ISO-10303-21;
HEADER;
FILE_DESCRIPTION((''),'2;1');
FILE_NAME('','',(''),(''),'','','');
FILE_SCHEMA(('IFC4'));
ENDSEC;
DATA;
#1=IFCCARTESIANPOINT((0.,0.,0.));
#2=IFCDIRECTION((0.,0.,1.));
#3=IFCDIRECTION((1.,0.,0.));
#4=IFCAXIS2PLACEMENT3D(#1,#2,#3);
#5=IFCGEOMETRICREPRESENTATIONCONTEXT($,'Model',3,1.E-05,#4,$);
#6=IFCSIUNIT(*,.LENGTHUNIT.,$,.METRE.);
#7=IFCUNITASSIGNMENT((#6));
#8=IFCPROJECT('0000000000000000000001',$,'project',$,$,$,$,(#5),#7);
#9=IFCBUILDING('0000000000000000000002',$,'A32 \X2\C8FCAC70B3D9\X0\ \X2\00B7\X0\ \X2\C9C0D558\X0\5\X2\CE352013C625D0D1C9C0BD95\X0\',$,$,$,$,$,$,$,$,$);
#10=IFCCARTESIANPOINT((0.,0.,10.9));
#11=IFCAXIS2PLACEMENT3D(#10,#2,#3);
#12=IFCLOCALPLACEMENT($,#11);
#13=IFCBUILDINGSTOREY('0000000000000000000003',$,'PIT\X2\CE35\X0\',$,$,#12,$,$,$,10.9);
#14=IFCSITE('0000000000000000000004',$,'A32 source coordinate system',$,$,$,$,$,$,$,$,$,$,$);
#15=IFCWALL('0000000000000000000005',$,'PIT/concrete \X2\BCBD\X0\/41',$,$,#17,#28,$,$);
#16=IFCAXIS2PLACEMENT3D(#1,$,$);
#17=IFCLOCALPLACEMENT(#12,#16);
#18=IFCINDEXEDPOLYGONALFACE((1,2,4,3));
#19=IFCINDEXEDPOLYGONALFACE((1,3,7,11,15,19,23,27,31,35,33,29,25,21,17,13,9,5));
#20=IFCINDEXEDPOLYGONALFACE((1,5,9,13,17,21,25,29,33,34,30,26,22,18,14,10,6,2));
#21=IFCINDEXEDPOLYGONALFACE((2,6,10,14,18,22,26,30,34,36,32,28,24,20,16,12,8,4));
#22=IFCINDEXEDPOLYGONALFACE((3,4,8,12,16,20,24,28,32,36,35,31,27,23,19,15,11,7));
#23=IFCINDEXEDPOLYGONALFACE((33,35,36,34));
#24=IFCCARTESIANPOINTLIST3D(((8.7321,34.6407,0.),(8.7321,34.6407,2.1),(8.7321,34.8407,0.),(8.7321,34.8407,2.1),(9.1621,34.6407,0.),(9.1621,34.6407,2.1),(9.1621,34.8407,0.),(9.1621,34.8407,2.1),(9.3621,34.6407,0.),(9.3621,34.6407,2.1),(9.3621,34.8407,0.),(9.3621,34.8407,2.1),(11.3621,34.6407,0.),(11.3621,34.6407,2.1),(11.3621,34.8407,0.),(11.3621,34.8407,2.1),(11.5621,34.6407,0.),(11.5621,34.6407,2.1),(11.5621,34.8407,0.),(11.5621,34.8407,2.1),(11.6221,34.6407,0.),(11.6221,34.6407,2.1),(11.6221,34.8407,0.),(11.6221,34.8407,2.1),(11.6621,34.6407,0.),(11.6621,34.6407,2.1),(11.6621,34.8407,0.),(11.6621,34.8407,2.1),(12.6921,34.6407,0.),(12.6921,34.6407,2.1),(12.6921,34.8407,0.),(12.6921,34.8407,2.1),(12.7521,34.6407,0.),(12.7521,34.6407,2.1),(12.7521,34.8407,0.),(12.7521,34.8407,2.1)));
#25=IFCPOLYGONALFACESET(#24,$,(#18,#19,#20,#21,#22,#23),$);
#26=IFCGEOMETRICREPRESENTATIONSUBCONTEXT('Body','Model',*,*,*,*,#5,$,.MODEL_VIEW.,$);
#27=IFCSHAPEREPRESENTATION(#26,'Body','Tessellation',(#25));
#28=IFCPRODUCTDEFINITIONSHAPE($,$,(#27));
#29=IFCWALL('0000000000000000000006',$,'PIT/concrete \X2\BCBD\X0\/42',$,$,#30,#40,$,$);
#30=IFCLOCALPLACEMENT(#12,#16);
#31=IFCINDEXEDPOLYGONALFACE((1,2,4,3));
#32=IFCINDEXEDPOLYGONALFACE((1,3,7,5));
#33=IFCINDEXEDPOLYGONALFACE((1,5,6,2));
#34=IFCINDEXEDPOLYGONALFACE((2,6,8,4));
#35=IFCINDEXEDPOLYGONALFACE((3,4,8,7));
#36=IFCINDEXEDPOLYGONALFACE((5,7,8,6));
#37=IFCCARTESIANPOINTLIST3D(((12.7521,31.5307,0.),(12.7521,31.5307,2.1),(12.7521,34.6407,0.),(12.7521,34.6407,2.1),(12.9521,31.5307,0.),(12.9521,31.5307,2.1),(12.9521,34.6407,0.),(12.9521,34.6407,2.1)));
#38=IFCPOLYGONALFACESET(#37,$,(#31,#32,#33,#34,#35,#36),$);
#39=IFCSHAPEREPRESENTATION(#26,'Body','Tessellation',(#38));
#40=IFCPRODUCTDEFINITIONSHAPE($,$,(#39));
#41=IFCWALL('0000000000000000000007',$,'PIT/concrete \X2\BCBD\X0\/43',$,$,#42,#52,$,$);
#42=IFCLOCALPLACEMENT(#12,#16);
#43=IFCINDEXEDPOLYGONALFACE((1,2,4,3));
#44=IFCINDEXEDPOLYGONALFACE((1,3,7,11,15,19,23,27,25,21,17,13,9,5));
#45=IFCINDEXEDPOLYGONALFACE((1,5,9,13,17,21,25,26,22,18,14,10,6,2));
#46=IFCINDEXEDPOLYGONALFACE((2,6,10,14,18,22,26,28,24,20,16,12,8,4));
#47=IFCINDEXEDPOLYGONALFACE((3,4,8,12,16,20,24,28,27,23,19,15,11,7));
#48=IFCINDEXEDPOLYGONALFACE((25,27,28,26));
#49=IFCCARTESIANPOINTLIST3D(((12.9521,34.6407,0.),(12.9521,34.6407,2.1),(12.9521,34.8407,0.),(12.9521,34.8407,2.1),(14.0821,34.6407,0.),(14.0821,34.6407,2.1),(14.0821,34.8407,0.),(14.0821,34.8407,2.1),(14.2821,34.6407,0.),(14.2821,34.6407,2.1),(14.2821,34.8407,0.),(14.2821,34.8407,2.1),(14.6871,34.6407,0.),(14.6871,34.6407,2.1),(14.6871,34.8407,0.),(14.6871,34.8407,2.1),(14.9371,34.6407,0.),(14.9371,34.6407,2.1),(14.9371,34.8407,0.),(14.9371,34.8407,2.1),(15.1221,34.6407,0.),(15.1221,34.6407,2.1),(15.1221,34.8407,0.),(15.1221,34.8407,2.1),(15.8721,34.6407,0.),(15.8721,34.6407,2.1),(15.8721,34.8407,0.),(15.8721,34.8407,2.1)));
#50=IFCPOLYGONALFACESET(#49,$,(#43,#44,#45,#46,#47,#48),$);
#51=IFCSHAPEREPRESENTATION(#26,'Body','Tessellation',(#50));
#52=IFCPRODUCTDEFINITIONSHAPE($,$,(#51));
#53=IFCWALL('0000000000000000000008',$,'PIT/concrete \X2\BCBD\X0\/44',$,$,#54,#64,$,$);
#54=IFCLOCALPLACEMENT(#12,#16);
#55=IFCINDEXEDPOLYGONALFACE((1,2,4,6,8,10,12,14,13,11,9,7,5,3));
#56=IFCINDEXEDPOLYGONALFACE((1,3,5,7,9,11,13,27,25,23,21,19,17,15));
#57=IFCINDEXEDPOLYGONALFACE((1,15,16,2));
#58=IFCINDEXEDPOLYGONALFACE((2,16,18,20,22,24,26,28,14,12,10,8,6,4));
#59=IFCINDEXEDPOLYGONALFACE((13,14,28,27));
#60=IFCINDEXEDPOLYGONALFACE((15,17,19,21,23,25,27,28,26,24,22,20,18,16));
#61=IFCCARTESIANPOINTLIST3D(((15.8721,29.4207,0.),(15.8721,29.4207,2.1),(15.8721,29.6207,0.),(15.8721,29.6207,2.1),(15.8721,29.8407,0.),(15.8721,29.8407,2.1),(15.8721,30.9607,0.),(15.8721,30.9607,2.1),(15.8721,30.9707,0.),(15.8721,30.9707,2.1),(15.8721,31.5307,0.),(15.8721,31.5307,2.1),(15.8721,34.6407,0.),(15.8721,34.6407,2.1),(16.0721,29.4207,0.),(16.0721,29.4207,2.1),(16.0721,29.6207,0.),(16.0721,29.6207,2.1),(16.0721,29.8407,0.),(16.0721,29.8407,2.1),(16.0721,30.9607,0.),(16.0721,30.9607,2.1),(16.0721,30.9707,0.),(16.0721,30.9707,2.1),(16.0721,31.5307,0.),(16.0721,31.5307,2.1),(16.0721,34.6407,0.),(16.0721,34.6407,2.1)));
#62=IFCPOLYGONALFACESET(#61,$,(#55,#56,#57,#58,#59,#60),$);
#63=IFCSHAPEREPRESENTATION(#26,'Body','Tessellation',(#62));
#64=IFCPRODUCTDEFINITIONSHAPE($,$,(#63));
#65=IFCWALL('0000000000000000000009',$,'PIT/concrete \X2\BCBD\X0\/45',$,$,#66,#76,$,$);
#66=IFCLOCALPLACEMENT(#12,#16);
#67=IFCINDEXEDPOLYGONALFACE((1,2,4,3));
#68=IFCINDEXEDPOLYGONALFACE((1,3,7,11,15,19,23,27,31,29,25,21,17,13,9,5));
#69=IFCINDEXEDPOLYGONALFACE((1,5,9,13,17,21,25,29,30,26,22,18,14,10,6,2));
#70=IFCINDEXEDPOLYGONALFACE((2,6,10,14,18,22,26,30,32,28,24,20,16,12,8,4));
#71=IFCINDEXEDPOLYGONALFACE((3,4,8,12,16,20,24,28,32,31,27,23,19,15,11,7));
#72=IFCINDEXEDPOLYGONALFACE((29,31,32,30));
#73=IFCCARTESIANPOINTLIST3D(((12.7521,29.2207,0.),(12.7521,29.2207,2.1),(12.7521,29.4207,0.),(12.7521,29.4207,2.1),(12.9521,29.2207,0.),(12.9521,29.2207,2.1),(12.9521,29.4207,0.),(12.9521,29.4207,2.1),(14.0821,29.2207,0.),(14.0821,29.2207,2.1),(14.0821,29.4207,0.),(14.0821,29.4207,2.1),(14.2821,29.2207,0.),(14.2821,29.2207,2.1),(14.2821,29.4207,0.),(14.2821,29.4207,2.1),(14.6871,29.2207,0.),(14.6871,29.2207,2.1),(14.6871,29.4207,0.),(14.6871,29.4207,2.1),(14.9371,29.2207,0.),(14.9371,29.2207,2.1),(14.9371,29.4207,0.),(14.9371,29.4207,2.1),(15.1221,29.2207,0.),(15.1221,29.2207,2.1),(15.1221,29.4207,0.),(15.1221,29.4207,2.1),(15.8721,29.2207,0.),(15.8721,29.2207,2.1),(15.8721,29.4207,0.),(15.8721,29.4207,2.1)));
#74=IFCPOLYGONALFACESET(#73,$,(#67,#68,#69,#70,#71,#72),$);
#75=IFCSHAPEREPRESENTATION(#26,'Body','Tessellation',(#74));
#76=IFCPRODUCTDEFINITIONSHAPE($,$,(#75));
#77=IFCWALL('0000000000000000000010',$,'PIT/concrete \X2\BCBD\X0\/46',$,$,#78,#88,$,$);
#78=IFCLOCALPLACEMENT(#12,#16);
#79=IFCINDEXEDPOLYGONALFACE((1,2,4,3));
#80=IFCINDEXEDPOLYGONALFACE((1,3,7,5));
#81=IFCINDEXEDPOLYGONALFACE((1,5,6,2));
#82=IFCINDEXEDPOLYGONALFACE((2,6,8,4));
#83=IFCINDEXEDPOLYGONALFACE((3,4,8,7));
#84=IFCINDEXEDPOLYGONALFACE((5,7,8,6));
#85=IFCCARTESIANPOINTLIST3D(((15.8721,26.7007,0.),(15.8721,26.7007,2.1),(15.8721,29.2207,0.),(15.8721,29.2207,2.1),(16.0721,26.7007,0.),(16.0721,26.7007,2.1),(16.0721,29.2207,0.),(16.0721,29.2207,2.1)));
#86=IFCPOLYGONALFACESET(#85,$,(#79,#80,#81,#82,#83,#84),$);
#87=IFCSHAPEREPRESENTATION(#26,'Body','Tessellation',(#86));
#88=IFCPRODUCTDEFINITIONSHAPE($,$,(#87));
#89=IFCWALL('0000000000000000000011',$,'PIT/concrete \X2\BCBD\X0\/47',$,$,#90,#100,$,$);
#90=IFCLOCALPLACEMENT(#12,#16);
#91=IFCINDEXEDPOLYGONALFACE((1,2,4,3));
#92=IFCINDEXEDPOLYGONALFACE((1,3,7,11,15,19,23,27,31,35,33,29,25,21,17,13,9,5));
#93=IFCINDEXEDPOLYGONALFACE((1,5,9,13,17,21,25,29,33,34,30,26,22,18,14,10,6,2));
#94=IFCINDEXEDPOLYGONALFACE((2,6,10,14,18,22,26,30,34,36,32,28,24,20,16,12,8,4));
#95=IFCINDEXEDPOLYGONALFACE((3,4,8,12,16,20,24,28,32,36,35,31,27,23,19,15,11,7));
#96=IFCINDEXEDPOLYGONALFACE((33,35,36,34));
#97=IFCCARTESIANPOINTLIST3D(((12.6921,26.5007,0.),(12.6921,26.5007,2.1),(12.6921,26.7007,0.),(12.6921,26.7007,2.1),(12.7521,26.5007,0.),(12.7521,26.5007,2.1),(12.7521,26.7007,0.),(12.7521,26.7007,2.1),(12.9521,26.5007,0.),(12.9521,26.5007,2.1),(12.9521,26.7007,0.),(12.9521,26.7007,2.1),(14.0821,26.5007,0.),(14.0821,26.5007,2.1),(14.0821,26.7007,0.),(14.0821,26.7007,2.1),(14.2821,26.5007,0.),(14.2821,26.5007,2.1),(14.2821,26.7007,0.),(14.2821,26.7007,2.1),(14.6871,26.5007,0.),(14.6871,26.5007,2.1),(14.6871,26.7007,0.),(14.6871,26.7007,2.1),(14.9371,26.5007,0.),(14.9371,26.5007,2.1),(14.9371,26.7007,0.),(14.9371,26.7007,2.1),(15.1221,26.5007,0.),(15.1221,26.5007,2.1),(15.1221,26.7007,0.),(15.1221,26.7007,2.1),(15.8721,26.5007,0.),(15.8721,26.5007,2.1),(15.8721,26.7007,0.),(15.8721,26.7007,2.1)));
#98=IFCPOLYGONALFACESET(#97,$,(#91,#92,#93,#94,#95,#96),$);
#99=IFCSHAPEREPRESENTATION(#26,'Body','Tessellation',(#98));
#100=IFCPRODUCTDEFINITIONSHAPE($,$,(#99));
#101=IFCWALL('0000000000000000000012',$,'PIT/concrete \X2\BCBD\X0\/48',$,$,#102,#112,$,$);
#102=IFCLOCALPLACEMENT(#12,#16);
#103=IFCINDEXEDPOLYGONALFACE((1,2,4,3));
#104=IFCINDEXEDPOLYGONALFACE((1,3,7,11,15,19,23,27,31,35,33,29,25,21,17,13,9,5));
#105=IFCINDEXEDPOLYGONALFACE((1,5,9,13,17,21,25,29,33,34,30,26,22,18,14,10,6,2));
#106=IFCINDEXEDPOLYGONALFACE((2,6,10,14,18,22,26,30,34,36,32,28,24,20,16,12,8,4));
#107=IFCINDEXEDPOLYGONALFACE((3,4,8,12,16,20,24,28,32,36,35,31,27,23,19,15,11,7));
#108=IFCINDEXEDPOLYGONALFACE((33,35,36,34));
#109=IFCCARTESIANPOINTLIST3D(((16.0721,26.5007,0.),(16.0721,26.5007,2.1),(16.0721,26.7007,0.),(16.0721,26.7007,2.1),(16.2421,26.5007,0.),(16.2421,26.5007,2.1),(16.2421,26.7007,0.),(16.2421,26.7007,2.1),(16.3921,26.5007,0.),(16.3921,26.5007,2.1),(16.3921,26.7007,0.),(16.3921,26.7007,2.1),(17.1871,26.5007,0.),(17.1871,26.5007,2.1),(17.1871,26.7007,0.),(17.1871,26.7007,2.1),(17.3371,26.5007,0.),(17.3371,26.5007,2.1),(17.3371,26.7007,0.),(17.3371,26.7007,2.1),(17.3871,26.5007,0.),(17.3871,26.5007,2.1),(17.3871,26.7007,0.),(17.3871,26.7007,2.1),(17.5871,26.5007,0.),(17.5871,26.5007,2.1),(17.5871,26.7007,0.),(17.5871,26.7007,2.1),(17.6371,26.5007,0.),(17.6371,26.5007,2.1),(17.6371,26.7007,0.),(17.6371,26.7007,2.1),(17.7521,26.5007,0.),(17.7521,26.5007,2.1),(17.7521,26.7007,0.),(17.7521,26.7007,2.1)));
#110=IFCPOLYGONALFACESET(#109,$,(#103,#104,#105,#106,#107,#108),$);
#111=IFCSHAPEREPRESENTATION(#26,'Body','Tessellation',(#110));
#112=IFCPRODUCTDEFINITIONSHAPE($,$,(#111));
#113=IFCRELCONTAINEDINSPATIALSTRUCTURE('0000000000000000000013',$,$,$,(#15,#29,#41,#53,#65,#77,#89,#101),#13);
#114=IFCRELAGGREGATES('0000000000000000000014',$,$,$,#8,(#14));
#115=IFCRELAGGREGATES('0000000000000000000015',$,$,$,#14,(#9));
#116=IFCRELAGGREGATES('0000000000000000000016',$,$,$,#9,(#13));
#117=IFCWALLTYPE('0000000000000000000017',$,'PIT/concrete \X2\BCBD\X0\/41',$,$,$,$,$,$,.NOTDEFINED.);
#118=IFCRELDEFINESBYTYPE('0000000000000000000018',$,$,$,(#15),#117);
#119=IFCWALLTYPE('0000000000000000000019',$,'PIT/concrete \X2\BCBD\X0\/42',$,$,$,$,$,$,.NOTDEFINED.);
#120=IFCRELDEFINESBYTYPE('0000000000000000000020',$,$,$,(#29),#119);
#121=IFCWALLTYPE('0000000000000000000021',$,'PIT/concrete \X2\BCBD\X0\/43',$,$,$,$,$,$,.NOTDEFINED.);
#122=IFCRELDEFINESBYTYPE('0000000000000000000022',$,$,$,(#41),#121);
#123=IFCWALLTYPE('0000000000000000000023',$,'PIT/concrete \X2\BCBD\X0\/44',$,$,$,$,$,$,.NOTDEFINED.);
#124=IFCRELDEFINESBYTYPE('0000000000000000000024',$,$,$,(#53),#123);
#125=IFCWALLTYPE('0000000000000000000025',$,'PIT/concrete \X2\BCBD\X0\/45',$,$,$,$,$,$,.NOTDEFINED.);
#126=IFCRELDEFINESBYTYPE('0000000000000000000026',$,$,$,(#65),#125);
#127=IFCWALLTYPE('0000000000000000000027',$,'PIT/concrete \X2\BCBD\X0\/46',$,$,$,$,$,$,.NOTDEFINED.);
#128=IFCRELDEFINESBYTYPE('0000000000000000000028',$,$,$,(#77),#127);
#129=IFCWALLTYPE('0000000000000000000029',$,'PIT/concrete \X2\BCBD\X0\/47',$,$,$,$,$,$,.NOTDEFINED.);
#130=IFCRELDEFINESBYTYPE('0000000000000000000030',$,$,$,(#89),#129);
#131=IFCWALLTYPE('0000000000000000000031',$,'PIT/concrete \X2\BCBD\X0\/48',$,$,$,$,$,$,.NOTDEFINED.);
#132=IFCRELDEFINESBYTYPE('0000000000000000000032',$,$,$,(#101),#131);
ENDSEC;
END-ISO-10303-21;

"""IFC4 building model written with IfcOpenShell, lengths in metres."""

from ifc_helpers import new_model, si_unit, frame, origin, origin_with_axes, place, context, subcontext, project, spatial, polyline, outline, extrude, source, transform, mapped, type_object, type_shapes, element, save


model = new_model("IFC4")

# Units and contexts
model_context = context("Model", 3, precision=1e-05, world=origin_with_axes())
body_context = subcontext(model_context, "Body", "Model", "MODEL_VIEW")
ifc_project = project(units=[si_unit("LENGTHUNIT", "METRE")], contexts=[model_context])

# Site, building, storey
site = spatial("IfcSite", under=ifc_project, Name="A32 source coordinate system")
building = spatial("IfcBuilding", under=site, Name="A32 주거동 · 지하5층–옥탑지붕")
storey_placement = place(None, frame((0.0, 0.0, 10.9), z_axis=(0.0, 0.0, 1.0), x_axis=(1.0, 0.0, 0.0)))
storey = spatial("IfcBuildingStorey", under=building, at=storey_placement, Name="PIT층", Elevation=10.9)

# Walls
wall_type_1 = type_object("IfcWallType", Name="PIT/concrete 벽/41", PredefinedType="NOTDEFINED")
shared_shape_1 = source(origin(), body_context, "Body", "SweptSolid", [
    extrude(outline(polyline([(9.3621, 34.8407), (11.3621, 34.8407), (11.5621, 34.8407), (11.6221, 34.8407), (11.6621, 34.8407), (12.6921, 34.8407), (12.7521, 34.8407), (12.7521, 34.6407), (12.6921, 34.6407), (11.6621, 34.6407), (11.6221, 34.6407), (11.5621, 34.6407), (11.3621, 34.6407), (9.3621, 34.6407), (9.1621, 34.6407), (8.7321, 34.6407), (8.7321, 34.8407), (9.1621, 34.8407), (9.3621, 34.8407)])), origin(), (0.0, 0.0, 1.0), 2.1),
])
type_shapes(wall_type_1, [shared_shape_1])
wall_1_placement = place(storey_placement, origin_with_axes())
element("IfcWall", 1, at=wall_1_placement, inside=storey, type_object=wall_type_1, Name="PIT/concrete 벽/41", context=body_context, shape_type="MappedRepresentation", body=[
    mapped(shared_shape_1, transform((0.0, 0.0, 0.0), scale=1.0)),
])
wall_type_2 = type_object("IfcWallType", Name="PIT/concrete 벽/42", PredefinedType="NOTDEFINED")
shared_shape_2 = source(origin(), body_context, "Body", "SweptSolid", [
    extrude(outline(polyline([(12.7521, 31.5307), (12.7521, 34.6407), (12.9521, 34.6407), (12.9521, 31.5307), (12.7521, 31.5307)])), origin(), (0.0, 0.0, 1.0), 2.1),
])
type_shapes(wall_type_2, [shared_shape_2])
wall_2_placement = place(storey_placement, origin_with_axes())
element("IfcWall", 2, at=wall_2_placement, inside=storey, type_object=wall_type_2, Name="PIT/concrete 벽/42", context=body_context, shape_type="MappedRepresentation", body=[
    mapped(shared_shape_2, transform((0.0, 0.0, 0.0), scale=1.0)),
])
wall_type_3 = type_object("IfcWallType", Name="PIT/concrete 벽/43", PredefinedType="NOTDEFINED")
shared_shape_3 = source(origin(), body_context, "Body", "SweptSolid", [
    extrude(outline(polyline([(14.2821, 34.8407), (14.6871, 34.8407), (14.9371, 34.8407), (15.1221, 34.8407), (15.8721, 34.8407), (15.8721, 34.6407), (15.1221, 34.6407), (14.9371, 34.6407), (14.6871, 34.6407), (14.2821, 34.6407), (14.0821, 34.6407), (12.9521, 34.6407), (12.9521, 34.8407), (14.0821, 34.8407), (14.2821, 34.8407)])), origin(), (0.0, 0.0, 1.0), 2.1),
])
type_shapes(wall_type_3, [shared_shape_3])
wall_3_placement = place(storey_placement, origin_with_axes())
element("IfcWall", 3, at=wall_3_placement, inside=storey, type_object=wall_type_3, Name="PIT/concrete 벽/43", context=body_context, shape_type="MappedRepresentation", body=[
    mapped(shared_shape_3, transform((0.0, 0.0, 0.0), scale=1.0)),
])
wall_type_4 = type_object("IfcWallType", Name="PIT/concrete 벽/44", PredefinedType="NOTDEFINED")
shared_shape_4 = source(origin(), body_context, "Body", "SweptSolid", [
    extrude(outline(polyline([(16.0721, 30.9707), (16.0721, 30.9607), (16.0721, 29.8407), (16.0721, 29.6207), (16.0721, 29.4207), (15.8721, 29.4207), (15.8721, 29.6207), (15.8721, 29.8407), (15.8721, 30.9607), (15.8721, 30.9707), (15.8721, 31.5307), (15.8721, 34.6407), (16.0721, 34.6407), (16.0721, 31.5307), (16.0721, 30.9707)])), origin(), (0.0, 0.0, 1.0), 2.1),
])
type_shapes(wall_type_4, [shared_shape_4])
wall_4_placement = place(storey_placement, origin_with_axes())
element("IfcWall", 4, at=wall_4_placement, inside=storey, type_object=wall_type_4, Name="PIT/concrete 벽/44", context=body_context, shape_type="MappedRepresentation", body=[
    mapped(shared_shape_4, transform((0.0, 0.0, 0.0), scale=1.0)),
])
wall_type_5 = type_object("IfcWallType", Name="PIT/concrete 벽/45", PredefinedType="NOTDEFINED")
shared_shape_5 = source(origin(), body_context, "Body", "SweptSolid", [
    extrude(outline(polyline([(14.9371, 29.2207), (14.6871, 29.2207), (14.2821, 29.2207), (14.0821, 29.2207), (12.9521, 29.2207), (12.7521, 29.2207), (12.7521, 29.4207), (12.9521, 29.4207), (14.0821, 29.4207), (14.2821, 29.4207), (14.6871, 29.4207), (14.9371, 29.4207), (15.1221, 29.4207), (15.8721, 29.4207), (15.8721, 29.2207), (15.1221, 29.2207), (14.9371, 29.2207)])), origin(), (0.0, 0.0, 1.0), 2.1),
])
type_shapes(wall_type_5, [shared_shape_5])
wall_5_placement = place(storey_placement, origin_with_axes())
element("IfcWall", 5, at=wall_5_placement, inside=storey, type_object=wall_type_5, Name="PIT/concrete 벽/45", context=body_context, shape_type="MappedRepresentation", body=[
    mapped(shared_shape_5, transform((0.0, 0.0, 0.0), scale=1.0)),
])
wall_type_6 = type_object("IfcWallType", Name="PIT/concrete 벽/46", PredefinedType="NOTDEFINED")
shared_shape_6 = source(origin(), body_context, "Body", "SweptSolid", [
    extrude(outline(polyline([(15.8721, 26.7007), (15.8721, 29.2207), (16.0721, 29.2207), (16.0721, 26.7007), (15.8721, 26.7007)])), origin(), (0.0, 0.0, 1.0), 2.1),
])
type_shapes(wall_type_6, [shared_shape_6])
wall_6_placement = place(storey_placement, origin_with_axes())
element("IfcWall", 6, at=wall_6_placement, inside=storey, type_object=wall_type_6, Name="PIT/concrete 벽/46", context=body_context, shape_type="MappedRepresentation", body=[
    mapped(shared_shape_6, transform((0.0, 0.0, 0.0), scale=1.0)),
])
wall_type_7 = type_object("IfcWallType", Name="PIT/concrete 벽/47", PredefinedType="NOTDEFINED")
shared_shape_7 = source(origin(), body_context, "Body", "SweptSolid", [
    extrude(outline(polyline([(14.9371, 26.5007), (14.6871, 26.5007), (14.2821, 26.5007), (14.0821, 26.5007), (12.9521, 26.5007), (12.7521, 26.5007), (12.6921, 26.5007), (12.6921, 26.7007), (12.7521, 26.7007), (12.9521, 26.7007), (14.0821, 26.7007), (14.2821, 26.7007), (14.6871, 26.7007), (14.9371, 26.7007), (15.1221, 26.7007), (15.8721, 26.7007), (15.8721, 26.5007), (15.1221, 26.5007), (14.9371, 26.5007)])), origin(), (0.0, 0.0, 1.0), 2.1),
])
type_shapes(wall_type_7, [shared_shape_7])
wall_7_placement = place(storey_placement, origin_with_axes())
element("IfcWall", 7, at=wall_7_placement, inside=storey, type_object=wall_type_7, Name="PIT/concrete 벽/47", context=body_context, shape_type="MappedRepresentation", body=[
    mapped(shared_shape_7, transform((0.0, 0.0, 0.0), scale=1.0)),
])
wall_type_8 = type_object("IfcWallType", Name="PIT/concrete 벽/48", PredefinedType="NOTDEFINED")
shared_shape_8 = source(origin(), body_context, "Body", "SweptSolid", [
    extrude(outline(polyline([(17.1871, 26.7007), (17.3371, 26.7007), (17.3871, 26.7007), (17.5871, 26.7007), (17.6371, 26.7007), (17.7521, 26.7007), (17.7521, 26.5007), (17.6371, 26.5007), (17.5871, 26.5007), (17.3871, 26.5007), (17.3371, 26.5007), (17.1871, 26.5007), (16.3921, 26.5007), (16.2421, 26.5007), (16.0721, 26.5007), (16.0721, 26.7007), (16.2421, 26.7007), (16.3921, 26.7007), (17.1871, 26.7007)])), origin(), (0.0, 0.0, 1.0), 2.1),
])
type_shapes(wall_type_8, [shared_shape_8])
wall_8_placement = place(storey_placement, origin_with_axes())
element("IfcWall", 8, at=wall_8_placement, inside=storey, type_object=wall_type_8, Name="PIT/concrete 벽/48", context=body_context, shape_type="MappedRepresentation", body=[
    mapped(shared_shape_8, transform((0.0, 0.0, 0.0), scale=1.0)),
])

save(model, "model.ifc")
